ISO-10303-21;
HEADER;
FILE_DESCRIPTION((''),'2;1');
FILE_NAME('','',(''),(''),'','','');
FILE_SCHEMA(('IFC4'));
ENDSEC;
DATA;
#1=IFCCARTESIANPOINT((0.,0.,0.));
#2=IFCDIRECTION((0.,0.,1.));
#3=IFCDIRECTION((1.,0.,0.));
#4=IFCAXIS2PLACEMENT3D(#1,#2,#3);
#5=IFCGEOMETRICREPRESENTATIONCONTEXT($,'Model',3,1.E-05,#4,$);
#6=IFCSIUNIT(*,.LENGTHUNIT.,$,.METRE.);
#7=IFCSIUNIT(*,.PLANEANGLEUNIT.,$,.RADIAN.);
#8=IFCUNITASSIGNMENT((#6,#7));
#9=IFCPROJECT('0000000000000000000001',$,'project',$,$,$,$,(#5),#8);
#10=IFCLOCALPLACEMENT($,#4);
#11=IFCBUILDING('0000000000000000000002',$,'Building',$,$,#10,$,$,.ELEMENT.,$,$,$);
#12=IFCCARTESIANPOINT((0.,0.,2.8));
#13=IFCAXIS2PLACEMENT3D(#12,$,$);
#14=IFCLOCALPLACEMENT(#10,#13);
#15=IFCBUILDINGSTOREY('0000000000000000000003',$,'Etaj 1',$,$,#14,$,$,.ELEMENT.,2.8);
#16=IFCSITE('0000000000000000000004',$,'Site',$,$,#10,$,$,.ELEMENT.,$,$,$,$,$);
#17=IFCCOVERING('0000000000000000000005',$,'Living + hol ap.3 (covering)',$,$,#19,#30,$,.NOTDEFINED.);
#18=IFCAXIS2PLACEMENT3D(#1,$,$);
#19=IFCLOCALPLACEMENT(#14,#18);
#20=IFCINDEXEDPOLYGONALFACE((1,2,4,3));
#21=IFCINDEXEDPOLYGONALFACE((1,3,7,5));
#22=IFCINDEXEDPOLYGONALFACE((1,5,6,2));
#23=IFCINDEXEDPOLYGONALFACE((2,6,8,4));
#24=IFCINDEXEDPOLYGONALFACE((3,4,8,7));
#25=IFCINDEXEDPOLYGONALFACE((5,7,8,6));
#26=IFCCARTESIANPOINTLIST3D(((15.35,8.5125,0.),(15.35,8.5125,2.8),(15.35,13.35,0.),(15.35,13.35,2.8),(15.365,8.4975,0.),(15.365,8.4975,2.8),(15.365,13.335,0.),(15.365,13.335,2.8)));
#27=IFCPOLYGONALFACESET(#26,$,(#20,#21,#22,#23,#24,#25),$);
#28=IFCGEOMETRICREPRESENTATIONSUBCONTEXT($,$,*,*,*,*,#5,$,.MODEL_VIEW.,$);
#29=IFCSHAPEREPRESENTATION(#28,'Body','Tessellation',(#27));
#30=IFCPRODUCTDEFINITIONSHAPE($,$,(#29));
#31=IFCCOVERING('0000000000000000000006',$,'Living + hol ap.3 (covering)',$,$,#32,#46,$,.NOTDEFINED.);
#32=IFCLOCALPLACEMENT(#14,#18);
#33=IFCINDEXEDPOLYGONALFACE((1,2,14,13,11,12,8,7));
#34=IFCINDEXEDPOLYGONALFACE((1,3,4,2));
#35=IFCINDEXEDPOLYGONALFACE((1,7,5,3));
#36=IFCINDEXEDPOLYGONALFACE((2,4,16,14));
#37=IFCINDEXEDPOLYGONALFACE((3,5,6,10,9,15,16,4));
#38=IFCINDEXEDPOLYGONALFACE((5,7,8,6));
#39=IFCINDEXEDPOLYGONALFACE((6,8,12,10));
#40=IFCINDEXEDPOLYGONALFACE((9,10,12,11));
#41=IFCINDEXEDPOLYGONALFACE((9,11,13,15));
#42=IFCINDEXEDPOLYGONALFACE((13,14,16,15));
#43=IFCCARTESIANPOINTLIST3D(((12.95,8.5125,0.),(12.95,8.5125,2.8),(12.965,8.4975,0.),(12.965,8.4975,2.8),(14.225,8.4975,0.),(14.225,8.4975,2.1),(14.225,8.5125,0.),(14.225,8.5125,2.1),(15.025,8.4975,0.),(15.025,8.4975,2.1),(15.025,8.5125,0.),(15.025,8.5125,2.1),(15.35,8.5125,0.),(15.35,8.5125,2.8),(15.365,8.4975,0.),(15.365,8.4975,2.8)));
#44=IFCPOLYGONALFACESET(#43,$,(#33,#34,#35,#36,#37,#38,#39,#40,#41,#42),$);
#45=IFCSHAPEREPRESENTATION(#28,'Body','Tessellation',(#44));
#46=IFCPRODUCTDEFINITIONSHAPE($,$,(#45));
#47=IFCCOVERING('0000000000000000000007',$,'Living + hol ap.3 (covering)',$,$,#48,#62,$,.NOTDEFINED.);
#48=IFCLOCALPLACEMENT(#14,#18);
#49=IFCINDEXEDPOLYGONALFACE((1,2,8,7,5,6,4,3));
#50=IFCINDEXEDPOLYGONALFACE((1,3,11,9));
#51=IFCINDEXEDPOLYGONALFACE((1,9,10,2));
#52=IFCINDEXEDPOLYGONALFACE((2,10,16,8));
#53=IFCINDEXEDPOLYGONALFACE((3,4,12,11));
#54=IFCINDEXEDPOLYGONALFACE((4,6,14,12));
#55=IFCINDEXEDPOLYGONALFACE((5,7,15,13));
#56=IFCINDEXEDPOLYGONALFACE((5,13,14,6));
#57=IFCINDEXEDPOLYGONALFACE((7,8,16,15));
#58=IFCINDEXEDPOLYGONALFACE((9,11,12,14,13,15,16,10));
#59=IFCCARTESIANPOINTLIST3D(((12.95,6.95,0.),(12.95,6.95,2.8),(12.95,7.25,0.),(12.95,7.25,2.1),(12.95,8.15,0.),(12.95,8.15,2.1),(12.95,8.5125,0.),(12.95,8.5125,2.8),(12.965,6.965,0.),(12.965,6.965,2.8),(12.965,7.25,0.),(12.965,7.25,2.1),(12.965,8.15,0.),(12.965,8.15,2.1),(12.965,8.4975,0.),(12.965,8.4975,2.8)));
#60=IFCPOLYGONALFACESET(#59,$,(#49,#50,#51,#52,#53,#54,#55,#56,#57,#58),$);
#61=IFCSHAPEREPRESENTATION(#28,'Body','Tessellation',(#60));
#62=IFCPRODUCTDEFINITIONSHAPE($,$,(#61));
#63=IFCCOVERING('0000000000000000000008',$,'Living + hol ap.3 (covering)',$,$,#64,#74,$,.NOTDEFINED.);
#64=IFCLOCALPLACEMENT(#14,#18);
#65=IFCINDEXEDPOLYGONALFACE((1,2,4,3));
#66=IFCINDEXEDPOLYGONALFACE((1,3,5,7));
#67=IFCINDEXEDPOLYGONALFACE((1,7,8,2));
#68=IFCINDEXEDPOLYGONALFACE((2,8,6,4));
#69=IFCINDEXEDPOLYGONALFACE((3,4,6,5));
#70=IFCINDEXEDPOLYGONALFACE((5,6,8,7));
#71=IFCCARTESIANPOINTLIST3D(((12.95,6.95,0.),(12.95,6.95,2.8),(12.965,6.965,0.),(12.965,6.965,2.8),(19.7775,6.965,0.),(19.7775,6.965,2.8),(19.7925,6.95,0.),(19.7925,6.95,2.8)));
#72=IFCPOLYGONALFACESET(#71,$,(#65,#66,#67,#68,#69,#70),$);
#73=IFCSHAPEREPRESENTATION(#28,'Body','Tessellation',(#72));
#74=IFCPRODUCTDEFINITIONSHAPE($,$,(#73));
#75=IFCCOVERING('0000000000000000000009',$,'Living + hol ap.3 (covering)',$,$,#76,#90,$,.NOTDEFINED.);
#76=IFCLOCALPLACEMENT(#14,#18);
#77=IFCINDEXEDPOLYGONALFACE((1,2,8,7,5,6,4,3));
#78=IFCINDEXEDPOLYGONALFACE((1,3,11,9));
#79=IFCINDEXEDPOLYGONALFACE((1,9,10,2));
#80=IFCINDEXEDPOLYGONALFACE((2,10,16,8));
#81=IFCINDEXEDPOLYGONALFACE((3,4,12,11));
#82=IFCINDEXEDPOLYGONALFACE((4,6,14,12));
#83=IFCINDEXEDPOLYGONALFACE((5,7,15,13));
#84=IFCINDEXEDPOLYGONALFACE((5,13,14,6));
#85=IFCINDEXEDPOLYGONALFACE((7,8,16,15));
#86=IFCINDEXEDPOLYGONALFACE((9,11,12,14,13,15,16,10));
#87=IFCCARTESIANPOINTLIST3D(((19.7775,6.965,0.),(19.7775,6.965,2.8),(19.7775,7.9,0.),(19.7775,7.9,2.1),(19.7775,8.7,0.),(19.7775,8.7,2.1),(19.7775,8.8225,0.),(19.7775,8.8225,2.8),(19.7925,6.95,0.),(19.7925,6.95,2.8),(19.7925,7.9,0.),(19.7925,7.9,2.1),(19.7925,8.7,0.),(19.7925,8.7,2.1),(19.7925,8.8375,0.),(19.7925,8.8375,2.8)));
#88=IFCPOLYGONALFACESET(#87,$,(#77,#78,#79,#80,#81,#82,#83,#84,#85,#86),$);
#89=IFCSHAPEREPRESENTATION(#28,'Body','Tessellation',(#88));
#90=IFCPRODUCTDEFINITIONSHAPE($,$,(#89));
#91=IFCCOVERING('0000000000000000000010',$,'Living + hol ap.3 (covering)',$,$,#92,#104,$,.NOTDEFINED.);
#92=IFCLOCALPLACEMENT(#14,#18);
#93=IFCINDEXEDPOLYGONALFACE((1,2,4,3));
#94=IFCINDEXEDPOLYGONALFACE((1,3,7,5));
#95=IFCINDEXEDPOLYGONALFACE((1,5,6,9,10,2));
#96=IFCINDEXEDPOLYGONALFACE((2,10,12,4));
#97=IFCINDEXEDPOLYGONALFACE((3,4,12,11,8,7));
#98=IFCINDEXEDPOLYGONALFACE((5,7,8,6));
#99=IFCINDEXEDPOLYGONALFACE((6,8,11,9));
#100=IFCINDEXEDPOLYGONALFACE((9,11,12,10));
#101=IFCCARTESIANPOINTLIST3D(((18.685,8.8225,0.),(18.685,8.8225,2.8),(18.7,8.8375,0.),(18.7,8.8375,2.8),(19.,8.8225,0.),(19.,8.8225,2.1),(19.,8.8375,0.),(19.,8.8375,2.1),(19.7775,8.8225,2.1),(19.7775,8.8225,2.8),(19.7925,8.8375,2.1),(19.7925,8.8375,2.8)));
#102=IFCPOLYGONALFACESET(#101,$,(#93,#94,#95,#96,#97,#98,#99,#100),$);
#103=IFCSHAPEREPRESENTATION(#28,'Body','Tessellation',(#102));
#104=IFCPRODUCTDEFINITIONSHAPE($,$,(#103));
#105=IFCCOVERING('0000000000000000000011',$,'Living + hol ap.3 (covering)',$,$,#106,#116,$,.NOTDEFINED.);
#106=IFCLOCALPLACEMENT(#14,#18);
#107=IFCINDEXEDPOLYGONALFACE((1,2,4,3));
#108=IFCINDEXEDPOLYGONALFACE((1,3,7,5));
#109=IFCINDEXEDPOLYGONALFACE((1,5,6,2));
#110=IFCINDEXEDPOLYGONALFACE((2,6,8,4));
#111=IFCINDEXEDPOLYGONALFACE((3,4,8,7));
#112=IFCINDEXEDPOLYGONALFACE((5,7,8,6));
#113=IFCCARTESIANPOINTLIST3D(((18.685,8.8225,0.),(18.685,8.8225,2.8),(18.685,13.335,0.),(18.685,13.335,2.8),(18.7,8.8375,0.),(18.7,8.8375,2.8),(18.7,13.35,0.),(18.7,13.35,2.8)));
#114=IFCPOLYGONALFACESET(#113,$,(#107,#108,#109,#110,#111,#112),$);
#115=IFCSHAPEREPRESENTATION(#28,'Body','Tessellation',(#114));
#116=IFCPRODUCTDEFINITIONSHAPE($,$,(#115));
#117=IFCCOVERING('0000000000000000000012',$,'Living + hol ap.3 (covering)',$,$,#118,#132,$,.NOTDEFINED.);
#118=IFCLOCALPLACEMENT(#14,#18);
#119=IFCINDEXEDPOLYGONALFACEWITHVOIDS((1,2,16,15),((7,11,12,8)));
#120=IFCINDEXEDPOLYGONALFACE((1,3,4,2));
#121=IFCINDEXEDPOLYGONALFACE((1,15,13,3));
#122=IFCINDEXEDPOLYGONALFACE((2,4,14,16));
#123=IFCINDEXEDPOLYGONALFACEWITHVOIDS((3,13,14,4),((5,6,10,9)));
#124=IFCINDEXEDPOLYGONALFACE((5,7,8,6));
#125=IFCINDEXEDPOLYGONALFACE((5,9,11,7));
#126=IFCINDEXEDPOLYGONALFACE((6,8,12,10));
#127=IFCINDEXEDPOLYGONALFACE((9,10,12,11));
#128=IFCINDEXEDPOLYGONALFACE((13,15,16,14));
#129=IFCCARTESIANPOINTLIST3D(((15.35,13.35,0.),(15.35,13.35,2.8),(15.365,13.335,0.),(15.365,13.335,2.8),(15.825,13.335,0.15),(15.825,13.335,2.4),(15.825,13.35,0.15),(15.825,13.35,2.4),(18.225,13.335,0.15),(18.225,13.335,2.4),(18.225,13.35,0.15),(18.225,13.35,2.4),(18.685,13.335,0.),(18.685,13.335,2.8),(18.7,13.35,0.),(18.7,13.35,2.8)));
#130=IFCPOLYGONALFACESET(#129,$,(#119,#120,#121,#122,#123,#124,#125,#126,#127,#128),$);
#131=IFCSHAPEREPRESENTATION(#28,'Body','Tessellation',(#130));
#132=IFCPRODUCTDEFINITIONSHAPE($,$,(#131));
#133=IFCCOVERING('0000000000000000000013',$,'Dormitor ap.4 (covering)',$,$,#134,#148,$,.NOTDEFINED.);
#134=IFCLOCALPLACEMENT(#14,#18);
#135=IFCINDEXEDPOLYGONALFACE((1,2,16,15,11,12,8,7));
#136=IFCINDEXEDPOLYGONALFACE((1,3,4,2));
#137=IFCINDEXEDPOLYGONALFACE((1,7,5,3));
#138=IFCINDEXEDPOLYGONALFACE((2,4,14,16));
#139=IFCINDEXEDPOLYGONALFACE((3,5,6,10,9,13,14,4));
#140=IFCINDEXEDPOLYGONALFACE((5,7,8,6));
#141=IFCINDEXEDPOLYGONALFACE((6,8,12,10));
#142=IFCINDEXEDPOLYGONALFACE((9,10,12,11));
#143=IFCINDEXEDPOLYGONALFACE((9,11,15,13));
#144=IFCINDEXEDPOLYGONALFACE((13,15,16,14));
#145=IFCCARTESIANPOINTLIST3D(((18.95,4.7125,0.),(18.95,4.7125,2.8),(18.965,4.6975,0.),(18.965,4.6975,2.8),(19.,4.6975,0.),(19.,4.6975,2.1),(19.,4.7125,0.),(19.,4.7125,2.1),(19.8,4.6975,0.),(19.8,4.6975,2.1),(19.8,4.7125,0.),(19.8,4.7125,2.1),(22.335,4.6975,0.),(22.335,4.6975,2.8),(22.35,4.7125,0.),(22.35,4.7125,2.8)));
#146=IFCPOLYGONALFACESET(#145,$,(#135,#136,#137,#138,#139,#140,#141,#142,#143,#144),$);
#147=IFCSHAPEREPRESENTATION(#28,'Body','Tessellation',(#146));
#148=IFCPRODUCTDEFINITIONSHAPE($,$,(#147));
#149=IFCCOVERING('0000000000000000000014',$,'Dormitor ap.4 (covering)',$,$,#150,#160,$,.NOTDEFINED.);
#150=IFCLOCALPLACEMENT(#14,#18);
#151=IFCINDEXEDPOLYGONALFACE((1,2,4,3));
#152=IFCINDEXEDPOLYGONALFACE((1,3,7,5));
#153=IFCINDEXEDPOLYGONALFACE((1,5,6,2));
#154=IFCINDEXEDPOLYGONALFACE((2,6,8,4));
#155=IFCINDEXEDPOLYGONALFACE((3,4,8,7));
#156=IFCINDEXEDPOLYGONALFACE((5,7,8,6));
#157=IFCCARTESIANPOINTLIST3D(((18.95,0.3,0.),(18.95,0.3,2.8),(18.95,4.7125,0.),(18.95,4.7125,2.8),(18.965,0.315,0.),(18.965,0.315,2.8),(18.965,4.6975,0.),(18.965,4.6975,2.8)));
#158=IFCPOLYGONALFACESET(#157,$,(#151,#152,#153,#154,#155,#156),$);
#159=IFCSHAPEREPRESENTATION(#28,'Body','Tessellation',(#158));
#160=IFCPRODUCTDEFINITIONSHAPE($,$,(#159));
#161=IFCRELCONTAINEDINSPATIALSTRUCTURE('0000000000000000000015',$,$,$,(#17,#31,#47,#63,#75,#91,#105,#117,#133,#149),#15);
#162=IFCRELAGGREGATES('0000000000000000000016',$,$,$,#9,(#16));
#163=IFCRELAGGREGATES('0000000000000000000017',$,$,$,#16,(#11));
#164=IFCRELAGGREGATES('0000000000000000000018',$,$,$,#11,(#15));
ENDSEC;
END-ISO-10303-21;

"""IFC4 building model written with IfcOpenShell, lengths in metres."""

from ifc_helpers import new_model, si_unit, frame, origin, origin_with_axes, origin_2d, place, context, subcontext, project, spatial, polyline, rectangle, outline, extrude, element, save


model = new_model("IFC4")

# Units and contexts
model_context = context("Model", 3, precision=1e-05, world=origin_with_axes())
sub_context = subcontext(model_context, None, None, "MODEL_VIEW")
ifc_project = project(units=[si_unit("LENGTHUNIT", "METRE"), si_unit("PLANEANGLEUNIT", "RADIAN")], contexts=[model_context])

# Site, building, storey
placement = place(None, origin_with_axes())
site = spatial("IfcSite", under=ifc_project, at=placement, Name="Site", CompositionType="ELEMENT")
building = spatial("IfcBuilding", under=site, at=placement, Name="Building", CompositionType="ELEMENT")
storey_placement = place(placement, frame((0.0, 0.0, 2.8)))
storey = spatial("IfcBuildingStorey", under=building, at=storey_placement, Name="Etaj 1", CompositionType="ELEMENT", Elevation=2.8)

# Covering
covering_1_placement = place(storey_placement, origin_with_axes())
element("IfcCovering", 1, at=covering_1_placement, inside=storey, Name="Living + hol ap.3 (covering)", PredefinedType="NOTDEFINED", context=sub_context, shape_type="SweptSolid", body=[
    extrude(outline(polyline([(15.35, 13.35), (15.35, 8.5125), (15.365, 8.4975), (15.365, 13.335), (15.35, 13.35)])), origin(), (0.0, 0.0, 1.0), 2.8),
])

# Coverings, openings
covering_2_placement = place(storey_placement, origin_with_axes())
covering_2 = element("IfcCovering", 2, at=covering_2_placement, inside=storey, Name="Living + hol ap.3 (covering)", PredefinedType="NOTDEFINED", context=sub_context, shape_type="SweptSolid", body=[
    extrude(outline(polyline([(15.35, 8.5125), (12.95, 8.5125), (12.965, 8.4975), (15.365, 8.4975), (15.35, 8.5125)])), origin(), (0.0, 0.0, 1.0), 2.8),
])
opening_1_placement = place(covering_2_placement, frame((14.625, 8.8275, 0.0), z_axis=(0.0, -1.0, 0.0), x_axis=(1.0, 0.0, 0.0)))
element("IfcOpeningElement", 3, at=opening_1_placement, cuts=covering_2, PredefinedType="OPENING", context=sub_context, shape_type="SweptSolid", body=[
    extrude(rectangle(XDim=0.8, YDim=2.1, at=origin_2d()), frame((0.0, 1.05, 0.0)), (0.0, 0.0, 1.0), 0.38),
])
covering_3_placement = place(storey_placement, origin_with_axes())
covering_3 = element("IfcCovering", 4, at=covering_3_placement, inside=storey, Name="Living + hol ap.3 (covering)", PredefinedType="NOTDEFINED", context=sub_context, shape_type="SweptSolid", body=[
    extrude(outline(polyline([(12.95, 8.5125), (12.95, 6.95), (12.965, 6.965), (12.965, 8.4975), (12.95, 8.5125)])), origin(), (0.0, 0.0, 1.0), 2.8),
])
opening_2_placement = place(covering_3_placement, frame((12.635, 7.7, 0.0), z_axis=(1.0, 0.0, 0.0), x_axis=(0.0, 1.0, 0.0)))
element("IfcOpeningElement", 5, at=opening_2_placement, cuts=covering_3, PredefinedType="OPENING", context=sub_context, shape_type="SweptSolid", body=[
    extrude(rectangle(XDim=0.9, YDim=2.1, at=origin_2d()), frame((0.0, 1.05, 0.0)), (0.0, 0.0, 1.0), 0.38),
])

# Covering
covering_4_placement = place(storey_placement, origin_with_axes())
element("IfcCovering", 6, at=covering_4_placement, inside=storey, Name="Living + hol ap.3 (covering)", PredefinedType="NOTDEFINED", context=sub_context, shape_type="SweptSolid", body=[
    extrude(outline(polyline([(12.95, 6.95), (19.7925, 6.95), (19.7775, 6.965), (12.965, 6.965), (12.95, 6.95)])), origin(), (0.0, 0.0, 1.0), 2.8),
])

# Coverings, openings
covering_5_placement = place(storey_placement, origin_with_axes())
covering_5 = element("IfcCovering", 7, at=covering_5_placement, inside=storey, Name="Living + hol ap.3 (covering)", PredefinedType="NOTDEFINED", context=sub_context, shape_type="SweptSolid", body=[
    extrude(outline(polyline([(19.7925, 6.95), (19.7925, 8.8375), (19.7775, 8.8225), (19.7775, 6.965), (19.7925, 6.95)])), origin(), (0.0, 0.0, 1.0), 2.8),
])
opening_3_placement = place(covering_5_placement, frame((19.7275, 8.3, 0.0), z_axis=(1.0, 0.0, 0.0), x_axis=(0.0, 1.0, 0.0)))
element("IfcOpeningElement", 8, at=opening_3_placement, cuts=covering_5, PredefinedType="OPENING", context=sub_context, shape_type="SweptSolid", body=[
    extrude(rectangle(XDim=0.8, YDim=2.1, at=origin_2d()), frame((0.0, 1.05, 0.0)), (0.0, 0.0, 1.0), 0.38),
])
covering_6_placement = place(storey_placement, origin_with_axes())
covering_6 = element("IfcCovering", 9, at=covering_6_placement, inside=storey, Name="Living + hol ap.3 (covering)", PredefinedType="NOTDEFINED", context=sub_context, shape_type="SweptSolid", body=[
    extrude(outline(polyline([(19.7925, 8.8375), (18.7, 8.8375), (18.685, 8.8225), (19.7775, 8.8225), (19.7925, 8.8375)])), origin(), (0.0, 0.0, 1.0), 2.8),
])
opening_4_placement = place(covering_6_placement, frame((19.4, 9.1525, 0.0), z_axis=(0.0, -1.0, 0.0), x_axis=(1.0, 0.0, 0.0)))
element("IfcOpeningElement", 10, at=opening_4_placement, cuts=covering_6, PredefinedType="OPENING", context=sub_context, shape_type="SweptSolid", body=[
    extrude(rectangle(XDim=0.8, YDim=2.1, at=origin_2d()), frame((0.0, 1.05, 0.0)), (0.0, 0.0, 1.0), 0.38),
])

# Covering
covering_7_placement = place(storey_placement, origin_with_axes())
element("IfcCovering", 11, at=covering_7_placement, inside=storey, Name="Living + hol ap.3 (covering)", PredefinedType="NOTDEFINED", context=sub_context, shape_type="SweptSolid", body=[
    extrude(outline(polyline([(18.7, 8.8375), (18.7, 13.35), (18.685, 13.335), (18.685, 8.8225), (18.7, 8.8375)])), origin(), (0.0, 0.0, 1.0), 2.8),
])

# Coverings, openings
covering_8_placement = place(storey_placement, origin_with_axes())
covering_8 = element("IfcCovering", 12, at=covering_8_placement, inside=storey, Name="Living + hol ap.3 (covering)", PredefinedType="NOTDEFINED", context=sub_context, shape_type="SweptSolid", body=[
    extrude(outline(polyline([(18.7, 13.35), (15.35, 13.35), (15.365, 13.335), (18.685, 13.335), (18.7, 13.35)])), origin(), (0.0, 0.0, 1.0), 2.8),
])
opening_5_placement = place(covering_8_placement, frame((17.025, 13.665, 0.15), z_axis=(0.0, -1.0, 0.0), x_axis=(1.0, 0.0, 0.0)))
element("IfcOpeningElement", 13, at=opening_5_placement, cuts=covering_8, PredefinedType="OPENING", context=sub_context, shape_type="SweptSolid", body=[
    extrude(rectangle(XDim=2.4, YDim=2.25, at=origin_2d()), frame((0.0, 1.125, 0.0)), (0.0, 0.0, 1.0), 0.38),
])
covering_9_placement = place(storey_placement, origin_with_axes())
covering_9 = element("IfcCovering", 14, at=covering_9_placement, inside=storey, Name="Dormitor ap.4 (covering)", PredefinedType="NOTDEFINED", context=sub_context, shape_type="SweptSolid", body=[
    extrude(outline(polyline([(22.35, 4.7125), (18.95, 4.7125), (18.965, 4.6975), (22.335, 4.6975), (22.35, 4.7125)])), origin(), (0.0, 0.0, 1.0), 2.8),
])
opening_6_placement = place(covering_9_placement, frame((19.4, 5.0275, 0.0), z_axis=(0.0, -1.0, 0.0), x_axis=(1.0, 0.0, 0.0)))
element("IfcOpeningElement", 15, at=opening_6_placement, cuts=covering_9, PredefinedType="OPENING", context=sub_context, shape_type="SweptSolid", body=[
    extrude(rectangle(XDim=0.8, YDim=2.1, at=origin_2d()), frame((0.0, 1.05, 0.0)), (0.0, 0.0, 1.0), 0.38),
])

# Covering
covering_10_placement = place(storey_placement, origin_with_axes())
element("IfcCovering", 16, at=covering_10_placement, inside=storey, Name="Dormitor ap.4 (covering)", PredefinedType="NOTDEFINED", context=sub_context, shape_type="SweptSolid", body=[
    extrude(outline(polyline([(18.95, 4.7125), (18.95, 0.3), (18.965, 0.315), (18.965, 4.6975), (18.95, 4.7125)])), origin(), (0.0, 0.0, 1.0), 2.8),
])

save(model, "model.ifc")
